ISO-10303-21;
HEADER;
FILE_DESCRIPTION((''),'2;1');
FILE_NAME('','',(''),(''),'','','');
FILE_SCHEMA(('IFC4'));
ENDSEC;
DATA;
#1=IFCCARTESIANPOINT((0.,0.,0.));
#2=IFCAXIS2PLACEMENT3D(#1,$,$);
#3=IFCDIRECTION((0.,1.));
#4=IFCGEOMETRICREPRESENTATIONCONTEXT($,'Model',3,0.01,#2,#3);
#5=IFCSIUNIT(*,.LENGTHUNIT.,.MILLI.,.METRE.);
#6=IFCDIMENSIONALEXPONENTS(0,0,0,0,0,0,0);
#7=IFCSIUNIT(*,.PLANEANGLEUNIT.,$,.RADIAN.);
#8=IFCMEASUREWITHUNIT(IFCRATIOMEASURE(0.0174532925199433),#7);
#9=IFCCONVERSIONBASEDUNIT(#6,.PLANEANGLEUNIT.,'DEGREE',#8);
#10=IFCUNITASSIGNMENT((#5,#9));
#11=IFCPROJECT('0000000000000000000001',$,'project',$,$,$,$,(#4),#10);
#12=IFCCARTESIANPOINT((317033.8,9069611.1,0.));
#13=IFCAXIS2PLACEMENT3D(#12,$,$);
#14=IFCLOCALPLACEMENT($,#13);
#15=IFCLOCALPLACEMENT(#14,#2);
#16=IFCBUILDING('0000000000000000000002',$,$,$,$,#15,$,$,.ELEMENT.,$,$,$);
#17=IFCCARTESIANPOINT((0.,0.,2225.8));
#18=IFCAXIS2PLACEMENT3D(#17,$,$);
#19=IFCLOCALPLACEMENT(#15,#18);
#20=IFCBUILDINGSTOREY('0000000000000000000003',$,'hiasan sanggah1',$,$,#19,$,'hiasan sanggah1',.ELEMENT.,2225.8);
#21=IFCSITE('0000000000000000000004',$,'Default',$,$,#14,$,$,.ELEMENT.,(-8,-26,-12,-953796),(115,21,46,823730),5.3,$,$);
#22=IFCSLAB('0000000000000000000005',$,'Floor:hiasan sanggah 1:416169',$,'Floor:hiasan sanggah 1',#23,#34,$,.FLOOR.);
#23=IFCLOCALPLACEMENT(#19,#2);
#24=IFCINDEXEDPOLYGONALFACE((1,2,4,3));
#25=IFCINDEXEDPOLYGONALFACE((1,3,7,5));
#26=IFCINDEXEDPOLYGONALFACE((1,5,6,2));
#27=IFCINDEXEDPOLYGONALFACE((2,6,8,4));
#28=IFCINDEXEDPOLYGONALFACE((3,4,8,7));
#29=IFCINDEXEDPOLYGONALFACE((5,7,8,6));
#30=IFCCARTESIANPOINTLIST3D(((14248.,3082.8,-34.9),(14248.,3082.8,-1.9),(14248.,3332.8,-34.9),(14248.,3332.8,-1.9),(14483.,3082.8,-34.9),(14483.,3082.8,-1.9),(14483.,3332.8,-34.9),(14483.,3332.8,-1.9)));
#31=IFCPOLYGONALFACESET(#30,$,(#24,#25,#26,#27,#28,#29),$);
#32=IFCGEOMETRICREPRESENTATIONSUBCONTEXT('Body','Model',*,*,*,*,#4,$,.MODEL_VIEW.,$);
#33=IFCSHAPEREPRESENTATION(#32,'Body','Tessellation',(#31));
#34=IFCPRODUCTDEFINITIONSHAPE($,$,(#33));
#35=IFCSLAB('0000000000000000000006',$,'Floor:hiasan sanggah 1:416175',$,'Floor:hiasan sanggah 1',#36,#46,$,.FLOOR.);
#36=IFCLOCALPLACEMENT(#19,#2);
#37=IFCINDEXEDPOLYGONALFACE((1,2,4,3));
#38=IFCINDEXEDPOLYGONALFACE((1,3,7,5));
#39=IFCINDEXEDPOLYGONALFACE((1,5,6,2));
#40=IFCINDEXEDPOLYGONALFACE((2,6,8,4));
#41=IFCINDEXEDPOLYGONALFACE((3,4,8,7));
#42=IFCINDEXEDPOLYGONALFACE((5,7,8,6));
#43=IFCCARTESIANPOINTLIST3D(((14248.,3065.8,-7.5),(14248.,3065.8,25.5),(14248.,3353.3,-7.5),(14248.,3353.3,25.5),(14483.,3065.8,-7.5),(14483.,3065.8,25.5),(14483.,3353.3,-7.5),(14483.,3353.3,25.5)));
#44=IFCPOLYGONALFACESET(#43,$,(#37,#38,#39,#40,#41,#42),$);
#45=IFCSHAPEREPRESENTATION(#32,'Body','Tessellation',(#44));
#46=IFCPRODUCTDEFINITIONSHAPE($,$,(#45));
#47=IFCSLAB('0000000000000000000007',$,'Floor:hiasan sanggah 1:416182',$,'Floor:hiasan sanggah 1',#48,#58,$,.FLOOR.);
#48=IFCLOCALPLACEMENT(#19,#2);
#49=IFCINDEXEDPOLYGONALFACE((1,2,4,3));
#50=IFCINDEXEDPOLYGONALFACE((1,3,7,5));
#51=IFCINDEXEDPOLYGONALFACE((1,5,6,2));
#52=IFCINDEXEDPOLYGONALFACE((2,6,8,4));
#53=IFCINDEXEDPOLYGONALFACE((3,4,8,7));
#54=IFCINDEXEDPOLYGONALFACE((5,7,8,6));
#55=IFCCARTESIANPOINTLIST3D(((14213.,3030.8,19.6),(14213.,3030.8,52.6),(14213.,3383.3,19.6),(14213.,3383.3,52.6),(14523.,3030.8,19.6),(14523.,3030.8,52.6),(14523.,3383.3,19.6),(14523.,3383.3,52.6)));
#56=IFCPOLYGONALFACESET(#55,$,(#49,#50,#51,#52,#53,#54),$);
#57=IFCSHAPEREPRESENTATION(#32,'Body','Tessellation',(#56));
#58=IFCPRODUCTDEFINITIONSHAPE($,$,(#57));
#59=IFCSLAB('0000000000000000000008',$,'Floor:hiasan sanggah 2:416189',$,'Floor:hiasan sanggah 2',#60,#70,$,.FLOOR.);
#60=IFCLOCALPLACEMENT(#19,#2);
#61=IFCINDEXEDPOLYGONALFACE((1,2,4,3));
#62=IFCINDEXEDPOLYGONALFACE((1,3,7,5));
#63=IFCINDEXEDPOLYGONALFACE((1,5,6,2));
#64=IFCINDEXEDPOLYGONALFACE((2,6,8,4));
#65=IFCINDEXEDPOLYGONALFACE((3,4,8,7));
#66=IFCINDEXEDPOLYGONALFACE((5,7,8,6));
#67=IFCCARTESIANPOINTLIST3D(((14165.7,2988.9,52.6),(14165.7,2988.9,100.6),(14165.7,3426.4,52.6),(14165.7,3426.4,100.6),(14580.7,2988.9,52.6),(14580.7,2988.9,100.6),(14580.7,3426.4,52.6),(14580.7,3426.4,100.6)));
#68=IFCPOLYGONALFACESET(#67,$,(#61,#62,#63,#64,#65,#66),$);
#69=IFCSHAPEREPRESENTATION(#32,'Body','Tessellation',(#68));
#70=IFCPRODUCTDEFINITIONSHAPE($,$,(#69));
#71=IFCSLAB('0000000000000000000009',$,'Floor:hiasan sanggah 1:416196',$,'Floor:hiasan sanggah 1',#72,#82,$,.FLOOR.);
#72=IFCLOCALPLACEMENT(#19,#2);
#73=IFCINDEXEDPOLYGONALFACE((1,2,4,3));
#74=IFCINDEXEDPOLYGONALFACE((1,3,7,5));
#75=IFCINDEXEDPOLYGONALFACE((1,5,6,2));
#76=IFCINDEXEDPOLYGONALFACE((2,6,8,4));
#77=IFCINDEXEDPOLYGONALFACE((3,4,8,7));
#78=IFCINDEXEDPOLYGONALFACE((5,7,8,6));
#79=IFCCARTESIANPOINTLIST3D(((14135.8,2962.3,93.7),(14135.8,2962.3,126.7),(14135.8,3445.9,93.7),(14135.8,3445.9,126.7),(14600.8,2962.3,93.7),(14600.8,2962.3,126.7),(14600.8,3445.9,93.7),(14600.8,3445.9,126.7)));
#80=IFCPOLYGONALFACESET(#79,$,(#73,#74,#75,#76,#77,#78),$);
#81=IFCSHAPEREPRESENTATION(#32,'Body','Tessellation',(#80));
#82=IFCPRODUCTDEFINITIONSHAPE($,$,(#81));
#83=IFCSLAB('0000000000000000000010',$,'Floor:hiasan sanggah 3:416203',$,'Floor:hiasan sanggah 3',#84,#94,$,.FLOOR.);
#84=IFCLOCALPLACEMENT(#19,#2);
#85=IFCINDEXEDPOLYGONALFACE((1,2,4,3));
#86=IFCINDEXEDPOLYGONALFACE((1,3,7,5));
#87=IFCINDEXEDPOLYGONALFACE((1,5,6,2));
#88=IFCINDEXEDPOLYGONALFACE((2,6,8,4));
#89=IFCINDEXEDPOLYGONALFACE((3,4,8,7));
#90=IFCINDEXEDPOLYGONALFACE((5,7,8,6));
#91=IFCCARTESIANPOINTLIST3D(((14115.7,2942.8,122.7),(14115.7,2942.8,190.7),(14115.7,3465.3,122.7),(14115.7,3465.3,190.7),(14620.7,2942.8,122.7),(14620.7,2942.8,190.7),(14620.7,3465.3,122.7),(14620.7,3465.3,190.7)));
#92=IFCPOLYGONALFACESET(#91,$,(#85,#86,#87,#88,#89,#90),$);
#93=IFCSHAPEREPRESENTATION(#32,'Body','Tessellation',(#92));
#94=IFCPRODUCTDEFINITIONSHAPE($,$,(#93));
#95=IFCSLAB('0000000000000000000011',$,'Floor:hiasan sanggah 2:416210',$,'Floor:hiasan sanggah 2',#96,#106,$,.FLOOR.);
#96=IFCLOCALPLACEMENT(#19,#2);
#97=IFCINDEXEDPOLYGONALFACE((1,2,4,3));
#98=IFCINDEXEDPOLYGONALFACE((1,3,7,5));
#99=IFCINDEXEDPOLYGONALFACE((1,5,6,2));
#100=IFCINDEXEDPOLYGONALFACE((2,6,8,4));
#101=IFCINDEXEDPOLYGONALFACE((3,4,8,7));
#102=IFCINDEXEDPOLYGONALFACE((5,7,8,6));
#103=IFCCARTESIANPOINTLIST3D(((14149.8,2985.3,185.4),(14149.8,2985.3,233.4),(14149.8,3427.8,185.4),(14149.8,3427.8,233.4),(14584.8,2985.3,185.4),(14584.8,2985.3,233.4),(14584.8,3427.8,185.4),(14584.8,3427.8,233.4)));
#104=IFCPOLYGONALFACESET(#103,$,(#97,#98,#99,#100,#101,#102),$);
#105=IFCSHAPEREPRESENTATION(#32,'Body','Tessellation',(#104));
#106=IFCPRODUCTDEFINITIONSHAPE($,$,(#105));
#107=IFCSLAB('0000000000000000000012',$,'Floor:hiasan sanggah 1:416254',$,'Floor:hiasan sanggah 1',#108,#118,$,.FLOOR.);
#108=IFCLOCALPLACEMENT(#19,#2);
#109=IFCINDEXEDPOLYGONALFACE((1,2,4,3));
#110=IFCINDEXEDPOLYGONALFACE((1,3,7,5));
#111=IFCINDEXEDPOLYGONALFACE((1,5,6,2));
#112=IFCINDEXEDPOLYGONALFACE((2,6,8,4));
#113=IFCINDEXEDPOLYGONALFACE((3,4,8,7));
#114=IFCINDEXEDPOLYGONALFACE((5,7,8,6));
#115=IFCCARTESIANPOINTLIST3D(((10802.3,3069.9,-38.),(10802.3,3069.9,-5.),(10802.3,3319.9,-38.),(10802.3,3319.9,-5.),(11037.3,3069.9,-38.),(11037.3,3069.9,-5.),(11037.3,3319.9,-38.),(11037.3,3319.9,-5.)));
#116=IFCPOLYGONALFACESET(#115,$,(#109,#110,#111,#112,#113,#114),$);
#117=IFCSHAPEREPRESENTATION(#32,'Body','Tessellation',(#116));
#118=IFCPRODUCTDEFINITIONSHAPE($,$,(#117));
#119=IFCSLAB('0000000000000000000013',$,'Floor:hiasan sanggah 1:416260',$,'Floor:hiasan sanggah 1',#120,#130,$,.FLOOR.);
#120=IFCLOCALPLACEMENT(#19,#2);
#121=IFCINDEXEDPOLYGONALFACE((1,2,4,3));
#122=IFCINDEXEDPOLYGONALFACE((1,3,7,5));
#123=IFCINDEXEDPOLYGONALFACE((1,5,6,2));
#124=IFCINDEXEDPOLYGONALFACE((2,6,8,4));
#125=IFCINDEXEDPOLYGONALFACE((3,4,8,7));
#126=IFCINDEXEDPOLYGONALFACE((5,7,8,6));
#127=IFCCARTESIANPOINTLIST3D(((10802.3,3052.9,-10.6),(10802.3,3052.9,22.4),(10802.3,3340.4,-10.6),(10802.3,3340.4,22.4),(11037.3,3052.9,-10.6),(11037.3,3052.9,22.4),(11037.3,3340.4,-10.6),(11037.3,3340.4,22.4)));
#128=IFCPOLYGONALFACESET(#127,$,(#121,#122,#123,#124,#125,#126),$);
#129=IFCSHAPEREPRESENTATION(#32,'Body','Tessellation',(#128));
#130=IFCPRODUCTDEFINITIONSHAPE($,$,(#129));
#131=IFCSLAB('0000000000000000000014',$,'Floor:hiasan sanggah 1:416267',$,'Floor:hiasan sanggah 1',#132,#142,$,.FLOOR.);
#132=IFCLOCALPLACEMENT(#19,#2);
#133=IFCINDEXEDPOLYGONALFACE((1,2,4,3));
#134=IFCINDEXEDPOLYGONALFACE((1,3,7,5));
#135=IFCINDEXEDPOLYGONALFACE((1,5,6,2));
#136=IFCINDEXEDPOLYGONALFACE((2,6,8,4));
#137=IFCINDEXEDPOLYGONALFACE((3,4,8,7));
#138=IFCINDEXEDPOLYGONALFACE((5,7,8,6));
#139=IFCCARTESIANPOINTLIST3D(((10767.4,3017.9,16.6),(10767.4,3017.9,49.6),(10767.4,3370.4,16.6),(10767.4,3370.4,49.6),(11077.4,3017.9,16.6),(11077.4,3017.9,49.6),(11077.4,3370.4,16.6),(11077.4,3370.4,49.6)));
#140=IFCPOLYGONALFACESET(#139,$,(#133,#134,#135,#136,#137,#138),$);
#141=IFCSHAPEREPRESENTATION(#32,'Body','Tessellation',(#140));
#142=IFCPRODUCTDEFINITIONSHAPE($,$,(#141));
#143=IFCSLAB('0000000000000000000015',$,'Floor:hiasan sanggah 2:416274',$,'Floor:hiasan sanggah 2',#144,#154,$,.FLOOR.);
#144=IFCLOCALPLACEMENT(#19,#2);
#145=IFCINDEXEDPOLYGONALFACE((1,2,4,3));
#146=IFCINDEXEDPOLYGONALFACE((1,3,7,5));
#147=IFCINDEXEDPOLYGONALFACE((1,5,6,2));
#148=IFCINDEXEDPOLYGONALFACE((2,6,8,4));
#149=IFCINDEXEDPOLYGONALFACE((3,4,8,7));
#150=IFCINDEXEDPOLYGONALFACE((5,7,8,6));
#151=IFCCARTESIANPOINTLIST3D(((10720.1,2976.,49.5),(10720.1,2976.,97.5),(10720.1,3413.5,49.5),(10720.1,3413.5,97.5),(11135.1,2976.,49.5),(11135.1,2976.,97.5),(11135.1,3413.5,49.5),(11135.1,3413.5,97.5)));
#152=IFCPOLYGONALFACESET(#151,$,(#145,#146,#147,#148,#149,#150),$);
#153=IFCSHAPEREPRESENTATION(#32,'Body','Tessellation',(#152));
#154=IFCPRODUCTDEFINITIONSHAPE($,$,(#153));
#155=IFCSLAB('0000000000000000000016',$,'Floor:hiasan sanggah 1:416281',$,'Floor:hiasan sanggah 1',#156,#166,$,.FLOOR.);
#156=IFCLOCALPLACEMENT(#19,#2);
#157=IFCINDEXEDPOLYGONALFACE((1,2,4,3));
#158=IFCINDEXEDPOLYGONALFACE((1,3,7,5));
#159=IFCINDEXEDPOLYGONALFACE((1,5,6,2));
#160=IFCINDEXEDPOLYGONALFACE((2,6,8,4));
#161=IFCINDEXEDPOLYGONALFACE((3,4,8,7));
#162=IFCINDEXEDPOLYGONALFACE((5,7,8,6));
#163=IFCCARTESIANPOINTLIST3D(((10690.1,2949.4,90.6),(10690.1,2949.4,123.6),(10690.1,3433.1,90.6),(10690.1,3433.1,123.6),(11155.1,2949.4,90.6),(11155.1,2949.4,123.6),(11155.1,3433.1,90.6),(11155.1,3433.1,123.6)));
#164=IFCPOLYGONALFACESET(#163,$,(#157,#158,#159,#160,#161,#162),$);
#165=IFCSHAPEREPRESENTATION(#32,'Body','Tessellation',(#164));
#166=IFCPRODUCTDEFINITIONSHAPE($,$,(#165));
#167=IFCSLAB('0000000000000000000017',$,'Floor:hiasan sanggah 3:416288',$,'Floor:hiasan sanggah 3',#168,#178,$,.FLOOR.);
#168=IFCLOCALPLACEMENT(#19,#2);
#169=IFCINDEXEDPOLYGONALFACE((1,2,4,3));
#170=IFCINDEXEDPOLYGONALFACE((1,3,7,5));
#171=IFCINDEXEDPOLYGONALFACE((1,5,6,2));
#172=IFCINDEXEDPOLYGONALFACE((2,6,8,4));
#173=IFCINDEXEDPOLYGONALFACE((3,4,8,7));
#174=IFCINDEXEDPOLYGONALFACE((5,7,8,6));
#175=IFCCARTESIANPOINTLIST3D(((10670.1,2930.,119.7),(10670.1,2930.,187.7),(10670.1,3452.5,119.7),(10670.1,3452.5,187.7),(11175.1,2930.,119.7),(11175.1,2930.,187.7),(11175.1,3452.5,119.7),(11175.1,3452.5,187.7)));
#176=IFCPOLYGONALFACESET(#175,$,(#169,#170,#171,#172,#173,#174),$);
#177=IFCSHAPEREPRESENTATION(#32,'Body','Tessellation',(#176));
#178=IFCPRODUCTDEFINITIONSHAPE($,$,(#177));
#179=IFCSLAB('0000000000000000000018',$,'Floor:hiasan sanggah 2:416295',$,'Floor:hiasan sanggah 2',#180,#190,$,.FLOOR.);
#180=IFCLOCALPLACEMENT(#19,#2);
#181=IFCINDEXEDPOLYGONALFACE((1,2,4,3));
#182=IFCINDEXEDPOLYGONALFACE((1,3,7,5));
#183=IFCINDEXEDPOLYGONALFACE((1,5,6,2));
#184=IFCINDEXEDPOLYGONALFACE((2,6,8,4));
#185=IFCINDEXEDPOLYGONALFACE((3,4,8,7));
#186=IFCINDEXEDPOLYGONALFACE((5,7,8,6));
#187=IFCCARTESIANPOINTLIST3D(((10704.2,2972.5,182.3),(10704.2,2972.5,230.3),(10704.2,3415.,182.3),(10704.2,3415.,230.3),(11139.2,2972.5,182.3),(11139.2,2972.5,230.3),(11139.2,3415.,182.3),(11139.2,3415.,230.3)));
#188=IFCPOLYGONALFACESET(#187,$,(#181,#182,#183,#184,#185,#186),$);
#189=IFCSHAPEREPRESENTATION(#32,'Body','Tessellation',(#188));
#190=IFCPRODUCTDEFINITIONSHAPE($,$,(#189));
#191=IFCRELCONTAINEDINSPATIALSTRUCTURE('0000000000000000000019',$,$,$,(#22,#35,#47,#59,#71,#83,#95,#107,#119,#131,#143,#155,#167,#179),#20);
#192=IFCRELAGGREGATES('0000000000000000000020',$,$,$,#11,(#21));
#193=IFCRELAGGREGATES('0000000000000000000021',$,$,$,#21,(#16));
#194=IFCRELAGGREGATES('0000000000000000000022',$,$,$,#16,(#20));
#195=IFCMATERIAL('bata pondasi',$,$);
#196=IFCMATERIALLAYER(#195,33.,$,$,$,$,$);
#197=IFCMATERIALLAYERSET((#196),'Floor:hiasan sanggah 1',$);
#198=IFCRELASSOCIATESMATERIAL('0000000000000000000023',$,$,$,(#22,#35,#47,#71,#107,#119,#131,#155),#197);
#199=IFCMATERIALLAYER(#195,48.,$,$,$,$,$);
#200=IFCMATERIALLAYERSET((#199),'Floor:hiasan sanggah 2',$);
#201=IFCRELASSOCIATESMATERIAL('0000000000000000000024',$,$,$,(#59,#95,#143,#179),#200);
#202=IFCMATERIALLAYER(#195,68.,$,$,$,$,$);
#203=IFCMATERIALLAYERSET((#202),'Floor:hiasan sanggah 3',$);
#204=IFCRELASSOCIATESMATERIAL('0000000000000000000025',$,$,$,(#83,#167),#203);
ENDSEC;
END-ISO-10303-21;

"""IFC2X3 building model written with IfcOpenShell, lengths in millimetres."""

from ifc_helpers import new_model, entity, si_unit, converted_unit, direction, frame, frame_2d, origin, origin_2d_with_axis, place, context, subcontext, project, spatial, rectangle, extrude, material, layer, layer_set, layer_usage, element, save


model = new_model("IFC2X3")

# Units and contexts
model_context = context("Model", 3, precision=0.01, world=origin(), true_north=direction((0.0, 1.0)))
body_context = subcontext(model_context, "Body", "Model", "MODEL_VIEW")
ifc_project = project(units=[si_unit("LENGTHUNIT", "METRE", prefix="MILLI"), converted_unit("PLANEANGLEUNIT", "DEGREE", entity("IfcRatioMeasure", 0.0174532925199433), si_unit("PLANEANGLEUNIT", "RADIAN"), dimensions=[0, 0, 0, 0, 0, 0, 0])], contexts=[model_context])

# Site, building, storey
site_placement = place(None, frame((317033.8, 9069611.1, 0.0)))
site = spatial("IfcSite", under=ifc_project, at=site_placement, Name="Default", CompositionType="ELEMENT", RefLatitude=(-8, -26, -12, -953796), RefLongitude=(115, 21, 46, 823730), RefElevation=5.3)
building_placement = place(site_placement, origin())
building = spatial("IfcBuilding", under=site, at=building_placement, CompositionType="ELEMENT")
storey_placement = place(building_placement, frame((0.0, 0.0, 2225.8)))
storey = spatial("IfcBuildingStorey", under=building, at=storey_placement, Name="hiasan sanggah1", LongName="hiasan sanggah1", CompositionType="ELEMENT", Elevation=2225.8)

# Slabs
ifc_material = material(Name="bata pondasi")
ifc_layer_1 = layer(ifc_material, 33.0)
ifc_layer_set_1 = layer_set([ifc_layer_1], Name="Floor:hiasan sanggah 1")
ifc_layer_usage_1 = layer_usage(ifc_layer_set_1, "AXIS3", "POSITIVE", 0.0)
slab_1_placement = place(storey_placement, origin())
element("IfcSlab", 1, at=slab_1_placement, inside=storey, material=ifc_layer_usage_1, Name="Floor:hiasan sanggah 1:416169", ObjectType="Floor:hiasan sanggah 1", PredefinedType="FLOOR", context=body_context, shape_type="SweptSolid", body=[
    extrude(rectangle(XDim=250.0, YDim=235.0, at=origin_2d_with_axis()), frame((14365.5, 3207.8, -1.9), z_axis=(0.0, 0.0, -1.0), x_axis=(0.0, 1.0, 0.0)), (0.0, 0.0, 1.0), 33.0),
])
ifc_layer_usage_2 = layer_usage(ifc_layer_set_1, "AXIS3", "POSITIVE", 0.0)
slab_2_placement = place(storey_placement, origin())
element("IfcSlab", 2, at=slab_2_placement, inside=storey, material=ifc_layer_usage_2, Name="Floor:hiasan sanggah 1:416175", ObjectType="Floor:hiasan sanggah 1", PredefinedType="FLOOR", context=body_context, shape_type="SweptSolid", body=[
    extrude(rectangle(XDim=287.5, YDim=235.0, at=frame_2d((0.0, 0.0), x_axis=(1.0, 0.0))), frame((14365.5, 3209.5, 25.5), z_axis=(0.0, 0.0, -1.0), x_axis=(0.0, 1.0, 0.0)), (0.0, 0.0, 1.0), 33.0),
])
ifc_layer_usage_3 = layer_usage(ifc_layer_set_1, "AXIS3", "POSITIVE", 0.0)
slab_3_placement = place(storey_placement, origin())
element("IfcSlab", 3, at=slab_3_placement, inside=storey, material=ifc_layer_usage_3, Name="Floor:hiasan sanggah 1:416182", ObjectType="Floor:hiasan sanggah 1", PredefinedType="FLOOR", context=body_context, shape_type="SweptSolid", body=[
    extrude(rectangle(XDim=352.5, YDim=310.0, at=origin_2d_with_axis()), frame((14368.0, 3207.0, 52.6), z_axis=(0.0, 0.0, -1.0), x_axis=(0.0, 1.0, 0.0)), (0.0, 0.0, 1.0), 33.0),
])
ifc_layer_2 = layer(ifc_material, 48.0)
ifc_layer_set_2 = layer_set([ifc_layer_2], Name="Floor:hiasan sanggah 2")
ifc_layer_usage_4 = layer_usage(ifc_layer_set_2, "AXIS3", "POSITIVE", 0.0)
slab_4_placement = place(storey_placement, origin())
element("IfcSlab", 4, at=slab_4_placement, inside=storey, material=ifc_layer_usage_4, Name="Floor:hiasan sanggah 2:416189", ObjectType="Floor:hiasan sanggah 2", PredefinedType="FLOOR", context=body_context, shape_type="SweptSolid", body=[
    extrude(rectangle(XDim=437.5, YDim=415.0, at=origin_2d_with_axis()), frame((14373.2, 3207.7, 100.6), z_axis=(0.0, 0.0, -1.0), x_axis=(0.0, 1.0, 0.0)), (0.0, 0.0, 1.0), 48.0),
])
ifc_layer_usage_5 = layer_usage(ifc_layer_set_1, "AXIS3", "POSITIVE", 0.0)
slab_5_placement = place(storey_placement, origin())
element("IfcSlab", 5, at=slab_5_placement, inside=storey, material=ifc_layer_usage_5, Name="Floor:hiasan sanggah 1:416196", ObjectType="Floor:hiasan sanggah 1", PredefinedType="FLOOR", context=body_context, shape_type="SweptSolid", body=[
    extrude(rectangle(XDim=483.7, YDim=465.0, at=origin_2d_with_axis()), frame((14368.3, 3204.1, 126.7), z_axis=(0.0, 0.0, -1.0), x_axis=(0.0, 1.0, 0.0)), (0.0, 0.0, 1.0), 33.0),
])
ifc_layer_3 = layer(ifc_material, 68.0)
ifc_layer_set_3 = layer_set([ifc_layer_3], Name="Floor:hiasan sanggah 3")
ifc_layer_usage_6 = layer_usage(ifc_layer_set_3, "AXIS3", "POSITIVE", 0.0)
slab_6_placement = place(storey_placement, origin())
element("IfcSlab", 6, at=slab_6_placement, inside=storey, material=ifc_layer_usage_6, Name="Floor:hiasan sanggah 3:416203", ObjectType="Floor:hiasan sanggah 3", PredefinedType="FLOOR", context=body_context, shape_type="SweptSolid", body=[
    extrude(rectangle(XDim=522.5, YDim=505.0, at=origin_2d_with_axis()), frame((14368.2, 3204.1, 190.7), z_axis=(0.0, 0.0, -1.0), x_axis=(0.0, 1.0, 0.0)), (0.0, 0.0, 1.0), 68.0),
])
ifc_layer_usage_7 = layer_usage(ifc_layer_set_2, "AXIS3", "POSITIVE", 0.0)
slab_7_placement = place(storey_placement, origin())
element("IfcSlab", 7, at=slab_7_placement, inside=storey, material=ifc_layer_usage_7, Name="Floor:hiasan sanggah 2:416210", ObjectType="Floor:hiasan sanggah 2", PredefinedType="FLOOR", context=body_context, shape_type="SweptSolid", body=[
    extrude(rectangle(XDim=442.5, YDim=435.0, at=origin_2d_with_axis()), frame((14367.3, 3206.6, 233.4), z_axis=(0.0, 0.0, -1.0), x_axis=(0.0, 1.0, 0.0)), (0.0, 0.0, 1.0), 48.0),
])
ifc_layer_usage_8 = layer_usage(ifc_layer_set_1, "AXIS3", "POSITIVE", 0.0)
slab_8_placement = place(storey_placement, origin())
element("IfcSlab", 8, at=slab_8_placement, inside=storey, material=ifc_layer_usage_8, Name="Floor:hiasan sanggah 1:416254", ObjectType="Floor:hiasan sanggah 1", PredefinedType="FLOOR", context=body_context, shape_type="SweptSolid", body=[
    extrude(rectangle(XDim=250.0, YDim=235.0, at=frame_2d((0.0, 0.0), x_axis=(1.0, 0.0))), frame((10919.8, 3194.9, -5.0), z_axis=(0.0, 0.0, -1.0), x_axis=(0.0, 1.0, 0.0)), (0.0, 0.0, 1.0), 33.0),
])
ifc_layer_usage_9 = layer_usage(ifc_layer_set_1, "AXIS3", "POSITIVE", 0.0)
slab_9_placement = place(storey_placement, origin())
element("IfcSlab", 9, at=slab_9_placement, inside=storey, material=ifc_layer_usage_9, Name="Floor:hiasan sanggah 1:416260", ObjectType="Floor:hiasan sanggah 1", PredefinedType="FLOOR", context=body_context, shape_type="SweptSolid", body=[
    extrude(rectangle(XDim=287.5, YDim=235.0, at=origin_2d_with_axis()), frame((10919.8, 3196.6, 22.4), z_axis=(0.0, 0.0, -1.0), x_axis=(0.0, 1.0, 0.0)), (0.0, 0.0, 1.0), 33.0),
])
ifc_layer_usage_10 = layer_usage(ifc_layer_set_1, "AXIS3", "POSITIVE", 0.0)
slab_10_placement = place(storey_placement, origin())
element("IfcSlab", 10, at=slab_10_placement, inside=storey, material=ifc_layer_usage_10, Name="Floor:hiasan sanggah 1:416267", ObjectType="Floor:hiasan sanggah 1", PredefinedType="FLOOR", context=body_context, shape_type="SweptSolid", body=[
    extrude(rectangle(XDim=352.5, YDim=310.0, at=origin_2d_with_axis()), frame((10922.4, 3194.1, 49.6), z_axis=(0.0, 0.0, -1.0), x_axis=(0.0, 1.0, 0.0)), (0.0, 0.0, 1.0), 33.0),
])
ifc_layer_usage_11 = layer_usage(ifc_layer_set_2, "AXIS3", "POSITIVE", 0.0)
slab_11_placement = place(storey_placement, origin())
element("IfcSlab", 11, at=slab_11_placement, inside=storey, material=ifc_layer_usage_11, Name="Floor:hiasan sanggah 2:416274", ObjectType="Floor:hiasan sanggah 2", PredefinedType="FLOOR", context=body_context, shape_type="SweptSolid", body=[
    extrude(rectangle(XDim=437.5, YDim=415.0, at=frame_2d((0.0, 0.0), x_axis=(1.0, 0.0))), frame((10927.6, 3194.8, 97.5), z_axis=(0.0, 0.0, -1.0), x_axis=(0.0, 1.0, 0.0)), (0.0, 0.0, 1.0), 48.0),
])
ifc_layer_usage_12 = layer_usage(ifc_layer_set_1, "AXIS3", "POSITIVE", 0.0)
slab_12_placement = place(storey_placement, origin())
element("IfcSlab", 12, at=slab_12_placement, inside=storey, material=ifc_layer_usage_12, Name="Floor:hiasan sanggah 1:416281", ObjectType="Floor:hiasan sanggah 1", PredefinedType="FLOOR", context=body_context, shape_type="SweptSolid", body=[
    extrude(rectangle(XDim=483.7, YDim=465.0, at=frame_2d((0.0, 0.0), x_axis=(1.0, 0.0))), frame((10922.6, 3191.2, 123.6), z_axis=(0.0, 0.0, -1.0), x_axis=(0.0, 1.0, 0.0)), (0.0, 0.0, 1.0), 33.0),
])
ifc_layer_usage_13 = layer_usage(ifc_layer_set_3, "AXIS3", "POSITIVE", 0.0)
slab_13_placement = place(storey_placement, origin())
element("IfcSlab", 13, at=slab_13_placement, inside=storey, material=ifc_layer_usage_13, Name="Floor:hiasan sanggah 3:416288", ObjectType="Floor:hiasan sanggah 3", PredefinedType="FLOOR", context=body_context, shape_type="SweptSolid", body=[
    extrude(rectangle(XDim=522.5, YDim=505.0, at=origin_2d_with_axis()), frame((10922.6, 3191.2, 187.7), z_axis=(0.0, 0.0, -1.0), x_axis=(0.0, 1.0, 0.0)), (0.0, 0.0, 1.0), 68.0),
])
ifc_layer_usage_14 = layer_usage(ifc_layer_set_2, "AXIS3", "POSITIVE", 0.0)
slab_14_placement = place(storey_placement, origin())
element("IfcSlab", 14, at=slab_14_placement, inside=storey, material=ifc_layer_usage_14, Name="Floor:hiasan sanggah 2:416295", ObjectType="Floor:hiasan sanggah 2", PredefinedType="FLOOR", context=body_context, shape_type="SweptSolid", body=[
    extrude(rectangle(XDim=442.5, YDim=435.0, at=origin_2d_with_axis()), frame((10921.7, 3193.7, 230.3), z_axis=(0.0, 0.0, -1.0), x_axis=(0.0, 1.0, 0.0)), (0.0, 0.0, 1.0), 48.0),
])

save(model, "model.ifc")
